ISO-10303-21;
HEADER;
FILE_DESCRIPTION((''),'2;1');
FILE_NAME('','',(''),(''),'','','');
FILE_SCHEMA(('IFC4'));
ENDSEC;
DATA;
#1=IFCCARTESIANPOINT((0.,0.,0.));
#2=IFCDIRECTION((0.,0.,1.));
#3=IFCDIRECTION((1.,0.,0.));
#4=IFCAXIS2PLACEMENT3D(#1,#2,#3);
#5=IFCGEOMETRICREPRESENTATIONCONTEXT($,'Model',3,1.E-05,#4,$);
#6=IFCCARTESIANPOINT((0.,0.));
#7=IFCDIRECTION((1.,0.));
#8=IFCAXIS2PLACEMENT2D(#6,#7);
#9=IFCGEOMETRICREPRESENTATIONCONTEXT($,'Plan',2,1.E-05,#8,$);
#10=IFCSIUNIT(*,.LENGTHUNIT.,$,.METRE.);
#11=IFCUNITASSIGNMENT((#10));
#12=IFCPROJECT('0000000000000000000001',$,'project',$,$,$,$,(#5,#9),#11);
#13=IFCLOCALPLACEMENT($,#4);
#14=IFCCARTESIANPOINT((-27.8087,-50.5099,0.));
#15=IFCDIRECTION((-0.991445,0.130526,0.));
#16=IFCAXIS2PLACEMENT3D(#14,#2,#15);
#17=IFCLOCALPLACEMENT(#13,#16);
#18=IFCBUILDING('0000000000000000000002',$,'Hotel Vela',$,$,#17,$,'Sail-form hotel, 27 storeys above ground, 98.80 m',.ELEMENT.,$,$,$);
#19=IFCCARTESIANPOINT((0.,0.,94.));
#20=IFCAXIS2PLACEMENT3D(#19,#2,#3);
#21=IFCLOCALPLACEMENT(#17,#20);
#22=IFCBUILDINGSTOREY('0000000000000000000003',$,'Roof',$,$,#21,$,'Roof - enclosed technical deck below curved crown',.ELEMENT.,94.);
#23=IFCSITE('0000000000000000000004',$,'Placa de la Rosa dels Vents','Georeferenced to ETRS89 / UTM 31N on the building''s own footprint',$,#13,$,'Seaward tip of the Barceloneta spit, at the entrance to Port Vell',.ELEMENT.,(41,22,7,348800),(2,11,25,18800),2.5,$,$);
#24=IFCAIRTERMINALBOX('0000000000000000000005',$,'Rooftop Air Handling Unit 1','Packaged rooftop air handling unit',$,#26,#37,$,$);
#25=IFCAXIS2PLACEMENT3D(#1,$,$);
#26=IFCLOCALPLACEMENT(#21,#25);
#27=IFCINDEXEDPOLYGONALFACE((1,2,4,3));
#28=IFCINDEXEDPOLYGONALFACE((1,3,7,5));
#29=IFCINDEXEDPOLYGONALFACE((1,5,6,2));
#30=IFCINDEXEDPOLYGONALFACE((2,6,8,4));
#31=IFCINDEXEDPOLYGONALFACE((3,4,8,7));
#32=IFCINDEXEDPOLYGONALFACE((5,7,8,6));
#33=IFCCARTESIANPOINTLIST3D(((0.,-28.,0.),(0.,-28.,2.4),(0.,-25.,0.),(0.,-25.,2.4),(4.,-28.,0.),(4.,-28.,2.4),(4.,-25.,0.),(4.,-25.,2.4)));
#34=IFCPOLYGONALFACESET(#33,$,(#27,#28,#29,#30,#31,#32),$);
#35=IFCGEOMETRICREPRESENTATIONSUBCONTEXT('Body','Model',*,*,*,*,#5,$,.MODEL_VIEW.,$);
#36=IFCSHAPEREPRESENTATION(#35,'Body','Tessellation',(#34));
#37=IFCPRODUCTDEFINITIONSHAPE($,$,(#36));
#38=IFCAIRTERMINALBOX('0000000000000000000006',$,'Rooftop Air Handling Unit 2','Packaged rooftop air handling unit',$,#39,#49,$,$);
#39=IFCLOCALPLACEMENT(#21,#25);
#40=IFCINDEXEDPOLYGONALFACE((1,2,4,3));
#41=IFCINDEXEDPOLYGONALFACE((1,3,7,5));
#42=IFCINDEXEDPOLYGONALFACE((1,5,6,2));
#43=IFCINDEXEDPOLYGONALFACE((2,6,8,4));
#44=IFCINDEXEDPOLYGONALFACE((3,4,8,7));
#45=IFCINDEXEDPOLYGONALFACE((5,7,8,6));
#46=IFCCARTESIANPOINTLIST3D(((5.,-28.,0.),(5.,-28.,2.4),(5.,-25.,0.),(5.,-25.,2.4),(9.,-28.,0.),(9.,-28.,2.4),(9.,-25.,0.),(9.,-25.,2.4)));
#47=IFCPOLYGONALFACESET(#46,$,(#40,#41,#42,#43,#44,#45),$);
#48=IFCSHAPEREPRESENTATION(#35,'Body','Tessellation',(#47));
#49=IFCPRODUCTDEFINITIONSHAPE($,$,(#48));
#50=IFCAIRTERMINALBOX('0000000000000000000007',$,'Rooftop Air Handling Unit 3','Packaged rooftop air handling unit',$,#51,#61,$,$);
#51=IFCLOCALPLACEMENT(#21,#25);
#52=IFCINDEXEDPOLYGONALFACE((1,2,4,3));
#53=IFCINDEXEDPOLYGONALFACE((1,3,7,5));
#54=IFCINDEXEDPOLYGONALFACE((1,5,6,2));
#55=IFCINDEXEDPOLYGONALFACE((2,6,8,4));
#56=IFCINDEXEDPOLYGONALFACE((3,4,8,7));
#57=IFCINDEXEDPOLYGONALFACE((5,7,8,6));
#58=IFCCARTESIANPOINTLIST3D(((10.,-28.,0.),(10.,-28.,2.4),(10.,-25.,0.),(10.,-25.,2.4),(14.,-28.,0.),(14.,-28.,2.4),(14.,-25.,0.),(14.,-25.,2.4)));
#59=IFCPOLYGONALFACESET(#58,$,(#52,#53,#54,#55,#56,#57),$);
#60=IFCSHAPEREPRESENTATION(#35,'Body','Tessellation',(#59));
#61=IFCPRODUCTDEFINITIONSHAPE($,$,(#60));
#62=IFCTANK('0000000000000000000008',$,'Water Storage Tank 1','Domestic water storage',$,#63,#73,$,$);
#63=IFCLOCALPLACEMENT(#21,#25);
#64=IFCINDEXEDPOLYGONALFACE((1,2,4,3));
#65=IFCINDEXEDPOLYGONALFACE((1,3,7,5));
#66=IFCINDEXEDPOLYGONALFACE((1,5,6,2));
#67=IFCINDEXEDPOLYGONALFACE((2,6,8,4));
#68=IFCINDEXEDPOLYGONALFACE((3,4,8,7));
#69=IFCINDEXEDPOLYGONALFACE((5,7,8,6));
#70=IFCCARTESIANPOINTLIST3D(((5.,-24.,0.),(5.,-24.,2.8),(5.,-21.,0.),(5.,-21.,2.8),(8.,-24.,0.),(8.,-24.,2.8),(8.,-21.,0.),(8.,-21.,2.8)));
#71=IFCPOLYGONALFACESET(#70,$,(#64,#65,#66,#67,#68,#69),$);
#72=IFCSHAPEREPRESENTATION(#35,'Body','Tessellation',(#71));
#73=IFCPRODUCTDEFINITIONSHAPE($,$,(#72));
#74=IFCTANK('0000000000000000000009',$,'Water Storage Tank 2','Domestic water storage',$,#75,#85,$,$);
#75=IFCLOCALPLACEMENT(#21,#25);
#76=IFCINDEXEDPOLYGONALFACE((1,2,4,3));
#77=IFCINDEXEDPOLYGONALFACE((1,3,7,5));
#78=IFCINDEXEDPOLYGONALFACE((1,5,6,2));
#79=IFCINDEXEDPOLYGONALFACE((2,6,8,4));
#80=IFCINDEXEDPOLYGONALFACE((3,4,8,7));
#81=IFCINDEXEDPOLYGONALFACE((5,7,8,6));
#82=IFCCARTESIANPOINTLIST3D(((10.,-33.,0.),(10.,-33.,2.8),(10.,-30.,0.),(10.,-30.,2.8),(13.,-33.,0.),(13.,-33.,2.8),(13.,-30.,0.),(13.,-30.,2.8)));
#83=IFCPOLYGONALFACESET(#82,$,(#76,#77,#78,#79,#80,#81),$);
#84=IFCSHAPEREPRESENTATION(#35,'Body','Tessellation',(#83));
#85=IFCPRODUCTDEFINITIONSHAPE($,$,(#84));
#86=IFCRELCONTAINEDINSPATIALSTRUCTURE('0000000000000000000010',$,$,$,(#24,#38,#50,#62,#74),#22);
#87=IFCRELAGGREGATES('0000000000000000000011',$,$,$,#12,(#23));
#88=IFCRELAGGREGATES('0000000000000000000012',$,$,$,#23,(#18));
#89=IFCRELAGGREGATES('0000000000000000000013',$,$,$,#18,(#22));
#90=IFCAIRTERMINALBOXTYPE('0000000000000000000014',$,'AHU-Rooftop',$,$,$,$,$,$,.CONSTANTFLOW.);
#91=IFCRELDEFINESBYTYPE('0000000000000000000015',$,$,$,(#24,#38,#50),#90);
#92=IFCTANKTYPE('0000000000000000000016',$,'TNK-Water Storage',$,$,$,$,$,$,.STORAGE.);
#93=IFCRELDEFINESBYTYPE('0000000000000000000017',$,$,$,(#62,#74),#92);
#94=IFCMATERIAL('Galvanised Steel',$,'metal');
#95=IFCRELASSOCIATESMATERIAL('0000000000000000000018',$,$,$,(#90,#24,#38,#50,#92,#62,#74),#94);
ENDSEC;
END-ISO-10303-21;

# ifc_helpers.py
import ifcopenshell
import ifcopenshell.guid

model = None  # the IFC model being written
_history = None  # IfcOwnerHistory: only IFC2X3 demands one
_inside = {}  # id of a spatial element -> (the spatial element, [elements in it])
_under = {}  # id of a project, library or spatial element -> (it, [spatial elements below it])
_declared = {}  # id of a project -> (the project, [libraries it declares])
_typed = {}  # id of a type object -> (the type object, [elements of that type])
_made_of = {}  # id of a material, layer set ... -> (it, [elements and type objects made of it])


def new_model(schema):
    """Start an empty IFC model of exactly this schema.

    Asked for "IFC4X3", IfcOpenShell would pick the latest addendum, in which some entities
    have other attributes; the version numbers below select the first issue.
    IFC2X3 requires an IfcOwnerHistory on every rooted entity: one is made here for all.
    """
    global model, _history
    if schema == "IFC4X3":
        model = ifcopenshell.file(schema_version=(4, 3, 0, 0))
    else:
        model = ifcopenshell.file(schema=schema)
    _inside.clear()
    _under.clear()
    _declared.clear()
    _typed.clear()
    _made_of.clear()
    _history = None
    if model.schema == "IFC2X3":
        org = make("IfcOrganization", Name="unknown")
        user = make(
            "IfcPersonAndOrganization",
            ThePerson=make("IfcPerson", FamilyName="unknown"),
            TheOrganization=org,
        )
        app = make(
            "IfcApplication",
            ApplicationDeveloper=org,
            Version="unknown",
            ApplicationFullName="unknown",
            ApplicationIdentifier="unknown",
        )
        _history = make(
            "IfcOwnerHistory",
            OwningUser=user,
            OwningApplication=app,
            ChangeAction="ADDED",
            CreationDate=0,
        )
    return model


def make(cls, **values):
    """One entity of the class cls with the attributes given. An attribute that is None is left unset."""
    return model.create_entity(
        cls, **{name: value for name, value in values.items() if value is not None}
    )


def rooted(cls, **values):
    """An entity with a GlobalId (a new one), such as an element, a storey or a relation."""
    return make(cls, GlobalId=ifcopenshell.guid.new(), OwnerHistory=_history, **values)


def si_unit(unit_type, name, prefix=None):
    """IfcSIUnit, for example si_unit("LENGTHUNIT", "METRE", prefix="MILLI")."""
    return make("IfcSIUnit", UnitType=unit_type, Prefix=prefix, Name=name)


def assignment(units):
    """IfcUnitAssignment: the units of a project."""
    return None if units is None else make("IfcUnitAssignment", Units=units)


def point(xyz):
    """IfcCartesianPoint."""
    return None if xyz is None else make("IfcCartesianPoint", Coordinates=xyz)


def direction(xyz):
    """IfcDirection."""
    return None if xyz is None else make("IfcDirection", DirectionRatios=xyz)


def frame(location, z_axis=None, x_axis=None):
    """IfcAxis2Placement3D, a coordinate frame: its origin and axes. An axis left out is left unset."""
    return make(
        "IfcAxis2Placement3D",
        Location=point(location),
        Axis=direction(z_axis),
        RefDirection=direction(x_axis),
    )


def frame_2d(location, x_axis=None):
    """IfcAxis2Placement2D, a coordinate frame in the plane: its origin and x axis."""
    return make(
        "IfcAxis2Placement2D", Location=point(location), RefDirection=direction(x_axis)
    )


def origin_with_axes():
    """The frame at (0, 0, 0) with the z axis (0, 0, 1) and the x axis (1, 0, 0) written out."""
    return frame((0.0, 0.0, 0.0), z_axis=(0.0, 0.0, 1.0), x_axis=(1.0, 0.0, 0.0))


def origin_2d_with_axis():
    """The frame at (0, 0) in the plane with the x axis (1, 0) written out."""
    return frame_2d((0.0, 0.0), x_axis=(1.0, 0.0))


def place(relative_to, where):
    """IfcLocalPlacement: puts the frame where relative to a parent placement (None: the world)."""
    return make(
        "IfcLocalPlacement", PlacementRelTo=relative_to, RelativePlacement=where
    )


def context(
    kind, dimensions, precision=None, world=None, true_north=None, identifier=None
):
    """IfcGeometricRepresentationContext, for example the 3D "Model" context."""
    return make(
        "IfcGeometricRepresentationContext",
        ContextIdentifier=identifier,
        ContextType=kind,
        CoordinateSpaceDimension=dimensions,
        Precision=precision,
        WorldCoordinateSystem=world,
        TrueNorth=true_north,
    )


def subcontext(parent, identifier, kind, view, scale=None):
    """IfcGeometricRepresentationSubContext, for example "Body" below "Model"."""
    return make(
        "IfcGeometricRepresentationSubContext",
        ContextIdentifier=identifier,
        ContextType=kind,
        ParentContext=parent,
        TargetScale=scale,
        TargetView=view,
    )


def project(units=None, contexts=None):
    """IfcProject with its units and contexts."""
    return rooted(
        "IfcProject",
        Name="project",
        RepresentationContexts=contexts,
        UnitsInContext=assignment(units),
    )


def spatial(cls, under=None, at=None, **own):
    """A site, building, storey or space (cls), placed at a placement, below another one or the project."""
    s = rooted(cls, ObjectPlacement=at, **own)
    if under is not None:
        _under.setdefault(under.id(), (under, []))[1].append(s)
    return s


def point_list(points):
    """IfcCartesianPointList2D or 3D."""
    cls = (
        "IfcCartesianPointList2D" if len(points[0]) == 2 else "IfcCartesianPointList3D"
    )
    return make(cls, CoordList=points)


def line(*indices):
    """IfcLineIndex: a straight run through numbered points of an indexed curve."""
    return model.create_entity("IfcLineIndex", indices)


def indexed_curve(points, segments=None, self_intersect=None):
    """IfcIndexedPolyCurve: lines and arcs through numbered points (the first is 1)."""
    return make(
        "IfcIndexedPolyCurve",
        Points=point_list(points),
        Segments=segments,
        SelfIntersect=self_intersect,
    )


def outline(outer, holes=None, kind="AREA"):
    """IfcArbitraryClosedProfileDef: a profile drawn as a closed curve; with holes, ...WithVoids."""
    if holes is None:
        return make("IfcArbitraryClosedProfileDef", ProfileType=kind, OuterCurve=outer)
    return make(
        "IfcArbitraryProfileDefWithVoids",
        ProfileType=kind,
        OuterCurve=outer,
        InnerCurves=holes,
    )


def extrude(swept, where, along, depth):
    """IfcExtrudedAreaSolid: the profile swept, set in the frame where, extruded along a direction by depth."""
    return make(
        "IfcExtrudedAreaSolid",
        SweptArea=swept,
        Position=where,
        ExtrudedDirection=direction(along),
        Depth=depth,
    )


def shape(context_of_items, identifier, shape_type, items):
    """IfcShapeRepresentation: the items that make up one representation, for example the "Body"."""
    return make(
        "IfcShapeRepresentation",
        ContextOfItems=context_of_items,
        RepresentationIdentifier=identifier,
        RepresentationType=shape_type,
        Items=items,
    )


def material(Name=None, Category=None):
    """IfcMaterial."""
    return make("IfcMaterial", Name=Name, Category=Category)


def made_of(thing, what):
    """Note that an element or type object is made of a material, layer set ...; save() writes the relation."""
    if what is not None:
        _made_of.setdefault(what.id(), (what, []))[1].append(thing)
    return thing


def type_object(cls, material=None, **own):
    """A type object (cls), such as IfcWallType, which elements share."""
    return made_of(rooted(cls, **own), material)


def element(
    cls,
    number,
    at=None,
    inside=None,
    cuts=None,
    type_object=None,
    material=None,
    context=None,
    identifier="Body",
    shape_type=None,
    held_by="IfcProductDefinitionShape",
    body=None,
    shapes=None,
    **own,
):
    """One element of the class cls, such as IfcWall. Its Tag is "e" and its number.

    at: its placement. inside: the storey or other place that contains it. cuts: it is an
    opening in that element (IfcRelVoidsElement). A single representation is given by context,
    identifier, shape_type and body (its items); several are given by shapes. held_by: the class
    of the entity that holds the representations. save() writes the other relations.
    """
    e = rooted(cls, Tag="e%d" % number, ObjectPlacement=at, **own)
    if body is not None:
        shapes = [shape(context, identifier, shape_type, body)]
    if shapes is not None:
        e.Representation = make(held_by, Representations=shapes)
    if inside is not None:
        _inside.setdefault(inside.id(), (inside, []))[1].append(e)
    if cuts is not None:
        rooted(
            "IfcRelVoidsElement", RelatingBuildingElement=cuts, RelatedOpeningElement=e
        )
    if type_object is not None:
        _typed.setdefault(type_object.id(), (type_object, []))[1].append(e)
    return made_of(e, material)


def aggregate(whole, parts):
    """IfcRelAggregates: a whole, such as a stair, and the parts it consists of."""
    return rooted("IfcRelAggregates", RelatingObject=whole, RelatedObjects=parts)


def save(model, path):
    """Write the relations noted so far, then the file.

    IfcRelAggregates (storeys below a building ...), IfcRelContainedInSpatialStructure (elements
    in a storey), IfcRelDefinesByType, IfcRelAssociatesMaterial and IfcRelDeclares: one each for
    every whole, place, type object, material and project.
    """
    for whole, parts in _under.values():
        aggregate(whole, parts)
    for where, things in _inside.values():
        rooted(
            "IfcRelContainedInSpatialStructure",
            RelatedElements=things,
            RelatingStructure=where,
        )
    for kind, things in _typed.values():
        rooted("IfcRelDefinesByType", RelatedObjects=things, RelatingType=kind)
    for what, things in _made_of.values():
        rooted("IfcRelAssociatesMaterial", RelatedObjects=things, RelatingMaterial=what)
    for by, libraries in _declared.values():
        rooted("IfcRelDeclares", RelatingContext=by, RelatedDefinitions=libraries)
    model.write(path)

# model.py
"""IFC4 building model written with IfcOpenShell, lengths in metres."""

from ifc_helpers import new_model, si_unit, frame, origin_with_axes, origin_2d_with_axis, place, context, subcontext, project, spatial, line, indexed_curve, outline, extrude, material, type_object, element, save


model = new_model("IFC4")

# Units and contexts
model_context = context("Model", 3, precision=1e-05, world=origin_with_axes())
plan_context = context("Plan", 2, precision=1e-05, world=origin_2d_with_axis())
body_context = subcontext(model_context, "Body", "Model", "MODEL_VIEW")
ifc_project = project(units=[si_unit("LENGTHUNIT", "METRE")], contexts=[model_context, plan_context])

# Site, building, storey
site_placement = place(None, origin_with_axes())
site = spatial("IfcSite", under=ifc_project, at=site_placement, Name="Placa de la Rosa dels Vents", Description="Georeferenced to ETRS89 / UTM 31N on the building's own footprint", LongName="Seaward tip of the Barceloneta spit, at the entrance to Port Vell", CompositionType="ELEMENT", RefLatitude=(41, 22, 7, 348800), RefLongitude=(2, 11, 25, 18800), RefElevation=2.5)
building_placement = place(site_placement, frame((-27.8087, -50.5099, 0.0), z_axis=(0.0, 0.0, 1.0), x_axis=(-0.991445, 0.130526, 0.0)))
building = spatial("IfcBuilding", under=site, at=building_placement, Name="Hotel Vela", LongName="Sail-form hotel, 27 storeys above ground, 98.80 m", CompositionType="ELEMENT")
storey_placement = place(building_placement, frame((0.0, 0.0, 94.0), z_axis=(0.0, 0.0, 1.0), x_axis=(1.0, 0.0, 0.0)))
storey = spatial("IfcBuildingStorey", under=building, at=storey_placement, Name="Roof", LongName="Roof - enclosed technical deck below curved crown", CompositionType="ELEMENT", Elevation=94.0)

# Air terminal boxes
ifc_material = material(Name="Galvanised Steel", Category="metal")
air_terminal_box_type = type_object("IfcAirTerminalBoxType", Name="AHU-Rooftop", PredefinedType="CONSTANTFLOW", material=ifc_material)
for number, where, z_axis, x_axis, name in (
    (1, (0.0, -28.0, 0.0), (0.0, 0.0, 1.0), (1.0, 0.0, 0.0), "Rooftop Air Handling Unit 1"),
    (2, (5.0, -28.0, 0.0), (0.0, 0.0, 1.0), (1.0, 0.0, 0.0), "Rooftop Air Handling Unit 2"),
    (3, (10.0, -28.0, 0.0), (0.0, 0.0, 1.0), (1.0, 0.0, 0.0), "Rooftop Air Handling Unit 3"),
):
    element("IfcAirTerminalBox", number, at=place(storey_placement, frame(where, z_axis=z_axis, x_axis=x_axis)), inside=storey, type_object=air_terminal_box_type, material=ifc_material, Name=name, Description="Packaged rooftop air handling unit", context=body_context, shape_type="SweptSolid", body=[
        extrude(outline(indexed_curve([(0.0, 0.0), (4.0, 0.0), (4.0, 3.0), (0.0, 3.0)], segments=[line(1, 2, 3, 4, 1)])), origin_with_axes(), (0.0, 0.0, 1.0), 2.4),
    ])

# Tanks
tank_type = type_object("IfcTankType", Name="TNK-Water Storage", PredefinedType="STORAGE", material=ifc_material)
for number, where, z_axis, x_axis, name in (
    (4, (5.0, -24.0, 0.0), (0.0, 0.0, 1.0), (1.0, 0.0, 0.0), "Water Storage Tank 1"),
    (5, (10.0, -33.0, 0.0), (0.0, 0.0, 1.0), (1.0, 0.0, 0.0), "Water Storage Tank 2"),
):
    element("IfcTank", number, at=place(storey_placement, frame(where, z_axis=z_axis, x_axis=x_axis)), inside=storey, type_object=tank_type, material=ifc_material, Name=name, Description="Domestic water storage", context=body_context, shape_type="SweptSolid", body=[
        extrude(outline(indexed_curve([(0.0, 0.0), (3.0, 0.0), (3.0, 3.0), (0.0, 3.0)], segments=[line(1, 2, 3, 4, 1)])), origin_with_axes(), (0.0, 0.0, 1.0), 2.8),
    ])

save(model, "model.ifc")
